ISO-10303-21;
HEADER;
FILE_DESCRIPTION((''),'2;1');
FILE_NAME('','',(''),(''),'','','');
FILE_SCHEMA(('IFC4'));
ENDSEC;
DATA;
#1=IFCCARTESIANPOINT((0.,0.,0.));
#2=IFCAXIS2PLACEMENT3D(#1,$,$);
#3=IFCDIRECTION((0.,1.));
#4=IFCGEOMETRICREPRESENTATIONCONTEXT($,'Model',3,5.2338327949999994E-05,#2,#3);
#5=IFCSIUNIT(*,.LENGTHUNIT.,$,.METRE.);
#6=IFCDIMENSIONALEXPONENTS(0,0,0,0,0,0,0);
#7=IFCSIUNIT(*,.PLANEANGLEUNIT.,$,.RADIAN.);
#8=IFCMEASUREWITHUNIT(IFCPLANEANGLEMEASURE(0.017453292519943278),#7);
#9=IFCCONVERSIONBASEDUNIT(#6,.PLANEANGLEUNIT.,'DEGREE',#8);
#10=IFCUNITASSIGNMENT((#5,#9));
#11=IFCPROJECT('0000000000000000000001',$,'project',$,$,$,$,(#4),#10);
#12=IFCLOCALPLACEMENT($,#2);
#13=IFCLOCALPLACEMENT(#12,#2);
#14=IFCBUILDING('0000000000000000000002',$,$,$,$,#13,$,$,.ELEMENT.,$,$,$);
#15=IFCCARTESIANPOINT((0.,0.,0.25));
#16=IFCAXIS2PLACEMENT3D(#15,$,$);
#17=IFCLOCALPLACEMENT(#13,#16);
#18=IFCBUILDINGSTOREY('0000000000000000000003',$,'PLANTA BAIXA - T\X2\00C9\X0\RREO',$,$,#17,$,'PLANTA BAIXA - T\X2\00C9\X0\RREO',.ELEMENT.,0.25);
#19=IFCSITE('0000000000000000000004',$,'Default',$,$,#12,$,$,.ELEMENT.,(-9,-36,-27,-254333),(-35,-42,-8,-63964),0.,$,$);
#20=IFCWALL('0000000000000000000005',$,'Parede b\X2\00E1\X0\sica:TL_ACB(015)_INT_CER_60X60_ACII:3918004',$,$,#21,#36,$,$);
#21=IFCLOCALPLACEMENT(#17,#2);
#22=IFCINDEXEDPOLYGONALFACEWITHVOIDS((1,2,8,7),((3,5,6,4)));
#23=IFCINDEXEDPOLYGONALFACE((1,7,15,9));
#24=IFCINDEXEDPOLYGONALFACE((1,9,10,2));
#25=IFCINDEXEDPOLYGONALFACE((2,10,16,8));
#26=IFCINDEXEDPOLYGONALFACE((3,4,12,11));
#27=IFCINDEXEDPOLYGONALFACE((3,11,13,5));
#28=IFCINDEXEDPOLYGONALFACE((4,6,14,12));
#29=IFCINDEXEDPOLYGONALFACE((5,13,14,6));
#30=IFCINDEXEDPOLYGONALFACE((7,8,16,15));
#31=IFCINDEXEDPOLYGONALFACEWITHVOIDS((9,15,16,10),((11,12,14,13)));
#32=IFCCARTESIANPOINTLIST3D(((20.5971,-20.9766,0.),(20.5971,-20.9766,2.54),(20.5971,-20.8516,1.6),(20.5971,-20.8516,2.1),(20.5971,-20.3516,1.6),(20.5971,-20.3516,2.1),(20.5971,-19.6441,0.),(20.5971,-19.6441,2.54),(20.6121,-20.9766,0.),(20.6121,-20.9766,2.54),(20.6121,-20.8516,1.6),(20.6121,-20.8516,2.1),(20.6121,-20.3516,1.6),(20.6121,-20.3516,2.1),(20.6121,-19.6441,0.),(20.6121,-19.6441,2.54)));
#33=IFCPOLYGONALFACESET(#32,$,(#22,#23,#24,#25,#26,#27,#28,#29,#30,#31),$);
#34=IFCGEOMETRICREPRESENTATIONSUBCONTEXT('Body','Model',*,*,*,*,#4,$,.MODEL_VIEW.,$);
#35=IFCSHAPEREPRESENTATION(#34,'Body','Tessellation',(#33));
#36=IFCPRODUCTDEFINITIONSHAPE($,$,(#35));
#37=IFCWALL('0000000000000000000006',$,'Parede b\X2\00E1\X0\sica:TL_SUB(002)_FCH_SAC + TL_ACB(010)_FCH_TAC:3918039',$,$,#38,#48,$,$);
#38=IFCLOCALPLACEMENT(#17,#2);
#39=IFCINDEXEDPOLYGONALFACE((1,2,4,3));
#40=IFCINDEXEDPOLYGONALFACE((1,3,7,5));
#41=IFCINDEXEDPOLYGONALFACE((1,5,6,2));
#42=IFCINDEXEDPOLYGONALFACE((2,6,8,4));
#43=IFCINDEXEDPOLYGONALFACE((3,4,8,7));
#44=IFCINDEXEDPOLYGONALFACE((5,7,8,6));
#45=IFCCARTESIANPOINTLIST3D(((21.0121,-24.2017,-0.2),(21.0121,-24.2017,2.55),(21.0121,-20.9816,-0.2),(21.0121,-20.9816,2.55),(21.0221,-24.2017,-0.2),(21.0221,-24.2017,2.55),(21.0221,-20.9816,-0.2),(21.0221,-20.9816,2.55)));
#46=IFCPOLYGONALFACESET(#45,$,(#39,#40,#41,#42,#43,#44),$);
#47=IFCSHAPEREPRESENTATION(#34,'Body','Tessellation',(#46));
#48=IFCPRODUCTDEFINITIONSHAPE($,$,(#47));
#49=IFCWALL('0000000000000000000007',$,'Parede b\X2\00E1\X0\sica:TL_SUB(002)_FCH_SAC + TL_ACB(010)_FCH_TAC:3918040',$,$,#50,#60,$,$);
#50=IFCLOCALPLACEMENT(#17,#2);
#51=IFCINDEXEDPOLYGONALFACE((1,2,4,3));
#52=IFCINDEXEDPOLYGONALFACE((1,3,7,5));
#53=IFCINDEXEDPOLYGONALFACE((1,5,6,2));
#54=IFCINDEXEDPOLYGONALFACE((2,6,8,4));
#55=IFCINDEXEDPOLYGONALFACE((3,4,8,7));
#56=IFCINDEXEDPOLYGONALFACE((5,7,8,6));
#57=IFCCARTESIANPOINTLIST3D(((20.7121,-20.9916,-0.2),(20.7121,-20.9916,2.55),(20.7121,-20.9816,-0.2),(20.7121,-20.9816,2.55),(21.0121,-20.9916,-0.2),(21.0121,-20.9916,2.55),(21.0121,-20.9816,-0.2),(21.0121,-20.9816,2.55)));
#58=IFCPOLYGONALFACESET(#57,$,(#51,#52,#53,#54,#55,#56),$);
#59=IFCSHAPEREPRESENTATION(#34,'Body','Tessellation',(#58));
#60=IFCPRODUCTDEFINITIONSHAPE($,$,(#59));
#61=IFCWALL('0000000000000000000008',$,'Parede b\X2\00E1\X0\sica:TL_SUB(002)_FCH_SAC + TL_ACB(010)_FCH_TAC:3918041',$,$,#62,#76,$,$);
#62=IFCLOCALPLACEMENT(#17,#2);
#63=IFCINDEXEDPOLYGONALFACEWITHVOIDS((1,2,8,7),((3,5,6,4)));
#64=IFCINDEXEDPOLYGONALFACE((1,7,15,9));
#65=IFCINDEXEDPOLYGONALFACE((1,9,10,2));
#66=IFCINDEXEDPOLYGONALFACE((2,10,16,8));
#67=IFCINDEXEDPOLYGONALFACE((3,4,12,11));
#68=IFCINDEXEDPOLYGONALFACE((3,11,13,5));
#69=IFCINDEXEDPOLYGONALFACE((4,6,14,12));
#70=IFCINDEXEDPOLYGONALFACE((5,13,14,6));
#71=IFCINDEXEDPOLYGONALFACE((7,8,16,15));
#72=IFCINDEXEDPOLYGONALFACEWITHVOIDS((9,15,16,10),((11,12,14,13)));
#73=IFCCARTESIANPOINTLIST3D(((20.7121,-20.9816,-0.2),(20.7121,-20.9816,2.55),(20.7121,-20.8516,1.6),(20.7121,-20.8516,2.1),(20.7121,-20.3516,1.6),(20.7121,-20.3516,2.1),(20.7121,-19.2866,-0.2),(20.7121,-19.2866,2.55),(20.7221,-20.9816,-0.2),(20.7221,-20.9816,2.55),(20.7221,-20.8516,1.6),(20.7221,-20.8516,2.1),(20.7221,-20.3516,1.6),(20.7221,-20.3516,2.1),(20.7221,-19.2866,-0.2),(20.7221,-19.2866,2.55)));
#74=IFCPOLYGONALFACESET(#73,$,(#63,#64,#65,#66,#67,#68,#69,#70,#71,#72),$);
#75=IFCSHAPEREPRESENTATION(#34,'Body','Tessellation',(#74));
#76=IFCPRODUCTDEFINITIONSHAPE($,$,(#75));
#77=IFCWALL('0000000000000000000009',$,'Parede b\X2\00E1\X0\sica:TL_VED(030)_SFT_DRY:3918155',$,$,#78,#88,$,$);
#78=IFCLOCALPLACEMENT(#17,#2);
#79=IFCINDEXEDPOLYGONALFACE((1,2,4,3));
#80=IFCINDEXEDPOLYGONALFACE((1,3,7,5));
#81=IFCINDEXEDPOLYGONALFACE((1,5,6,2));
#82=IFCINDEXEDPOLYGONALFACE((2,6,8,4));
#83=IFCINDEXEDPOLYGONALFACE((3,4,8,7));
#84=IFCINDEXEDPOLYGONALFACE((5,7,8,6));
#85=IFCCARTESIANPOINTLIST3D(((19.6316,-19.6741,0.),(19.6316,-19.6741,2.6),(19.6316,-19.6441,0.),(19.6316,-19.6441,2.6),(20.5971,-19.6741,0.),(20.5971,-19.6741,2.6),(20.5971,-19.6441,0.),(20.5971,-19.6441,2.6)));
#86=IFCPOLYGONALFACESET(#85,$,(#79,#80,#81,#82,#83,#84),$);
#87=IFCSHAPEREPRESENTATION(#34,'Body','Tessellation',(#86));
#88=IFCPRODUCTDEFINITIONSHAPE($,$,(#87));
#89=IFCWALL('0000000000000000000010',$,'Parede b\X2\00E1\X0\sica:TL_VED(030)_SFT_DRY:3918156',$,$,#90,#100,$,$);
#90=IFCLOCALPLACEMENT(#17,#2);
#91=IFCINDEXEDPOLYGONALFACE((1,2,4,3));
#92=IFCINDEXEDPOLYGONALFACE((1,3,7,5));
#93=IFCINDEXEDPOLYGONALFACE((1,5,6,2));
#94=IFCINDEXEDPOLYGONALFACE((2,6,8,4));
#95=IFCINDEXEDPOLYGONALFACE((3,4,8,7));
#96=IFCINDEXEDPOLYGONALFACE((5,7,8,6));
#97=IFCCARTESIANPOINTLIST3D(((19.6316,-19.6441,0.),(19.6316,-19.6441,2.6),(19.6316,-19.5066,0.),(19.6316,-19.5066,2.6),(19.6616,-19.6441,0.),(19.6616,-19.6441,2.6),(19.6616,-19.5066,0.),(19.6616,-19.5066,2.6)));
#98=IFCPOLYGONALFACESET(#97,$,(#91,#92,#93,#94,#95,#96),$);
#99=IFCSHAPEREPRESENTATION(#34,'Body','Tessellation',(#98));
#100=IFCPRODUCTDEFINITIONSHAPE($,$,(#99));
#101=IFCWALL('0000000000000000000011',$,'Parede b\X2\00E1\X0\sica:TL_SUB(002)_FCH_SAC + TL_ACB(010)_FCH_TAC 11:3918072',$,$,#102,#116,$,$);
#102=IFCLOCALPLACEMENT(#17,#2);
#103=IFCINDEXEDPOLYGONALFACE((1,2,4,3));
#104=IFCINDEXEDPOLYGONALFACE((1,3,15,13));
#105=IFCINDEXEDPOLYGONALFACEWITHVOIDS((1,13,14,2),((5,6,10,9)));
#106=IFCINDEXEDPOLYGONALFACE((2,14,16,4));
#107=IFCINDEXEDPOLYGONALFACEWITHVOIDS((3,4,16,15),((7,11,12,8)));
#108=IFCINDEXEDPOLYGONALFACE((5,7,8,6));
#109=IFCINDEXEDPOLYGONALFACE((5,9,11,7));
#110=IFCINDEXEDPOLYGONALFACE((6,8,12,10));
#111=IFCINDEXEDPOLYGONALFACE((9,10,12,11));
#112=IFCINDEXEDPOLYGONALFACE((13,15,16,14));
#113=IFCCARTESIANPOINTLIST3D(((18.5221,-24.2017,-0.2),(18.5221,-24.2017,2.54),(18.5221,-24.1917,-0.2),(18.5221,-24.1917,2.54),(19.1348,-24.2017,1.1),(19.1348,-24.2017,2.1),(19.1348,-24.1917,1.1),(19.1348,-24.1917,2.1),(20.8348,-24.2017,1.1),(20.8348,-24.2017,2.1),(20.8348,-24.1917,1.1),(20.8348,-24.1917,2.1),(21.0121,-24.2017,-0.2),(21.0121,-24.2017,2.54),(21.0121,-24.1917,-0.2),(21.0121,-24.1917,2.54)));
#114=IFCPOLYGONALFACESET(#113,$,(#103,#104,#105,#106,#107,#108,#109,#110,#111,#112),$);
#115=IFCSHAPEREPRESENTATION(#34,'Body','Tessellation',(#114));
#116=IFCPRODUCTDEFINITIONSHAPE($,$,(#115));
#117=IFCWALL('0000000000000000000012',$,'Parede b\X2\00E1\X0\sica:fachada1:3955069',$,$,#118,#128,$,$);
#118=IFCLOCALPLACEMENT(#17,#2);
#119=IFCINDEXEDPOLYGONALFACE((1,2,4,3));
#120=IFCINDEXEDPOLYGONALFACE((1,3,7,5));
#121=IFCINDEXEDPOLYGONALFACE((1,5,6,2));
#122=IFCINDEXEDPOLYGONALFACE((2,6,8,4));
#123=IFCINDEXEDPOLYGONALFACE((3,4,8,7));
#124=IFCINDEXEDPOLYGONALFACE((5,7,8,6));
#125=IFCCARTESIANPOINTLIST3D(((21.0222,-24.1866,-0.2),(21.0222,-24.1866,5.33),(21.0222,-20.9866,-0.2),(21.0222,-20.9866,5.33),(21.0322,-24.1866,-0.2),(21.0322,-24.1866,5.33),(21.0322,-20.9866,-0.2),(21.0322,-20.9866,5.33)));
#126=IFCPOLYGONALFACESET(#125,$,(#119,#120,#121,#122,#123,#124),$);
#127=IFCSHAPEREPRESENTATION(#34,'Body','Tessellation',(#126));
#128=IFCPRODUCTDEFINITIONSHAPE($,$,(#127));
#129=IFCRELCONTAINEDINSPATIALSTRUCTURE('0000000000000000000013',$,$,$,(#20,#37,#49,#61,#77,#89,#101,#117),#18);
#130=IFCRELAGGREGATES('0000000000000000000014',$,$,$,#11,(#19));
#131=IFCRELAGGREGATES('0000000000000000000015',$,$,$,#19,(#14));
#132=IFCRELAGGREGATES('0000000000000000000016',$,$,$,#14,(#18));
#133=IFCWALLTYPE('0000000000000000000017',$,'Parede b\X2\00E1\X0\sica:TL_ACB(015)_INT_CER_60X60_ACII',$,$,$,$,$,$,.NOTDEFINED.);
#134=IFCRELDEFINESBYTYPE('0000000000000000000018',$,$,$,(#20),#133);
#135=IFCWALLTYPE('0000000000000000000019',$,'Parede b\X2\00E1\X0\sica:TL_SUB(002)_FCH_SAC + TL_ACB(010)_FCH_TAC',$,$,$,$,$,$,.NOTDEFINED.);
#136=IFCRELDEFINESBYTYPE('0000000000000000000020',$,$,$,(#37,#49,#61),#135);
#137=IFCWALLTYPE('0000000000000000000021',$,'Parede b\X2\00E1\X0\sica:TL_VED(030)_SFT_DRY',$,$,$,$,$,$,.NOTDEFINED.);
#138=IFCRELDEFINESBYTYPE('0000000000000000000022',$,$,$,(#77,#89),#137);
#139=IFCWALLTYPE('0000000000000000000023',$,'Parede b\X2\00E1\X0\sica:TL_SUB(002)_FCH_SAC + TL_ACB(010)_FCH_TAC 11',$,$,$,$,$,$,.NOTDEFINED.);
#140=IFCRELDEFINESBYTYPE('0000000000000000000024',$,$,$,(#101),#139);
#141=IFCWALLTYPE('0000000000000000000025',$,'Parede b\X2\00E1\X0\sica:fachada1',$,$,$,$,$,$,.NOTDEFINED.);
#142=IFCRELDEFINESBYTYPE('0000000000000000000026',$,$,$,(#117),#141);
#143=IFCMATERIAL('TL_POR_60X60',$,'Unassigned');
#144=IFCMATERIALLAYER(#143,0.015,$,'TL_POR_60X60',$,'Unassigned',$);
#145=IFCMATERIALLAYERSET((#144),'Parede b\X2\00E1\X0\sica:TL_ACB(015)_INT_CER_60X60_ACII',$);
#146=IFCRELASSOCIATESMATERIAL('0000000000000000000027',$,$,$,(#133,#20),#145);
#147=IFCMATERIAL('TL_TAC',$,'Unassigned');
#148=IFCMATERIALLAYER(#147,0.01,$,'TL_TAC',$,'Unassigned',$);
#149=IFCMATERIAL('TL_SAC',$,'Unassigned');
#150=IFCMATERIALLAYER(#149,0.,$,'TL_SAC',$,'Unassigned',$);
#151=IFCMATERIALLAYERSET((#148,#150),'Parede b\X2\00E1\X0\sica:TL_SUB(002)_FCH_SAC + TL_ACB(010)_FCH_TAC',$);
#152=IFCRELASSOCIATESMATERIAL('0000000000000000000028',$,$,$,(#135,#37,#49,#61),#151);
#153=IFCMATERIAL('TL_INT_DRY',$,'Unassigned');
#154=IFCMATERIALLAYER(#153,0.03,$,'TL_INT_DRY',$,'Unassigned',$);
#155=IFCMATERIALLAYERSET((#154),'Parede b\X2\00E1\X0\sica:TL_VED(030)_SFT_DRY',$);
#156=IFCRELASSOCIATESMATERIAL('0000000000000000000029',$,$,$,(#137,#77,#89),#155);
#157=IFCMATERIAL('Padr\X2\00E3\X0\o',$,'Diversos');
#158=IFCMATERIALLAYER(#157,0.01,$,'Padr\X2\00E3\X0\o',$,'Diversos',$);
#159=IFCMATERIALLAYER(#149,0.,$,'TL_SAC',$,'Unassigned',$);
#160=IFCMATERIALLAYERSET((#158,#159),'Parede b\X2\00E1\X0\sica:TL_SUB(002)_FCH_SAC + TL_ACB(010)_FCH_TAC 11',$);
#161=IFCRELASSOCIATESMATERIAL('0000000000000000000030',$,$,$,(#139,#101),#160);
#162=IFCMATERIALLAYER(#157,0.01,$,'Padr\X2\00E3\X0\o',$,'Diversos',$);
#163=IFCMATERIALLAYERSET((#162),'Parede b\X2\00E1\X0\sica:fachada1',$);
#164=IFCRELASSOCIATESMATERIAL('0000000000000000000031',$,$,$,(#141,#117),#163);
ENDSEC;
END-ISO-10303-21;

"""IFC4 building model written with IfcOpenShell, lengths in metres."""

from ifc_helpers import new_model, entity, si_unit, converted_unit, direction, frame, frame_2d, origin, place, context, subcontext, project, spatial, rectangle, extrude, material, layer, layer_set, layer_usage, type_object, element, save


model = new_model("IFC4")

# Units and contexts
model_context = context("Model", 3, precision=5.2338327949999994e-05, world=origin(), true_north=direction((0.0, 1.0)))
body_context = subcontext(model_context, "Body", "Model", "MODEL_VIEW")
ifc_project = project(units=[si_unit("LENGTHUNIT", "METRE"), converted_unit("PLANEANGLEUNIT", "DEGREE", entity("IfcPlaneAngleMeasure", 0.017453292519943278), si_unit("PLANEANGLEUNIT", "RADIAN"), dimensions=[0, 0, 0, 0, 0, 0, 0])], contexts=[model_context])

# Site, building, storey
site_placement = place(None, frame((0.0, 0.0, 0.0)))
site = spatial("IfcSite", under=ifc_project, at=site_placement, Name="Default", CompositionType="ELEMENT", RefLatitude=(-9, -36, -27, -254333), RefLongitude=(-35, -42, -8, -63964), RefElevation=0.0)
building_placement = place(site_placement, origin())
building = spatial("IfcBuilding", under=site, at=building_placement, CompositionType="ELEMENT")
storey_placement = place(building_placement, frame((0.0, 0.0, 0.25)))
storey = spatial("IfcBuildingStorey", under=building, at=storey_placement, Name="PLANTA BAIXA - TÉRREO", LongName="PLANTA BAIXA - TÉRREO", CompositionType="ELEMENT", Elevation=0.25)

# Shared definitions
ifc_material_1 = material(Name="TL_SAC", Category="Unassigned")

# Shared definitions
ifc_material_2 = material(Name="TL_POR_60X60", Category="Unassigned")
ifc_layer_1 = layer(ifc_material_2, 0.015, Name="TL_POR_60X60", Category="Unassigned")
ifc_layer_set_1 = layer_set([ifc_layer_1], Name="Parede básica:TL_ACB(015)_INT_CER_60X60_ACII")
wall_type_1 = type_object("IfcWallType", Name="Parede básica:TL_ACB(015)_INT_CER_60X60_ACII", PredefinedType="NOTDEFINED", material=ifc_layer_set_1)

# Wall, opening
ifc_layer_usage_1 = layer_usage(ifc_layer_set_1, "AXIS2", "NEGATIVE", 0.0075)
wall_1_placement = place(storey_placement, frame((20.6046, -20.9766, 0.0), z_axis=(0.0, 0.0, 1.0), x_axis=(0.0, 1.0, 0.0)))
wall_1 = element("IfcWall", 1, at=wall_1_placement, inside=storey, type_object=wall_type_1, material=ifc_layer_usage_1, Name="Parede básica:TL_ACB(015)_INT_CER_60X60_ACII:3918004", context=body_context, shape_type="SweptSolid", body=[
    extrude(rectangle(XDim=1.3325, YDim=0.015, at=frame_2d((0.6662, 0.0), x_axis=(-1.0, 0.0))), origin(), (0.0, 0.0, 1.0), 2.54),
])
opening_1_placement = place(wall_1_placement, frame((20.9766, 20.6046, 1.6)))
element("IfcOpeningElement", 2, at=opening_1_placement, cuts=wall_1, PredefinedType="OPENING", context=body_context, shape_type="SweptSolid", body=[
    extrude(rectangle(XDim=0.5, YDim=0.5, at=frame_2d((0.0, 0.0), x_axis=(1.0, 0.0))), frame((-20.6016, -22.2361, 0.25), z_axis=(0.0, 1.0, 0.0), x_axis=(0.0, 0.0, 1.0)), (0.0, 0.0, 1.0), 3.048),
])

# Walls
ifc_material_3 = material(Name="TL_TAC", Category="Unassigned")
ifc_layer_2 = layer(ifc_material_3, 0.01, Name="TL_TAC", Category="Unassigned")
ifc_layer_3 = layer(ifc_material_1, 0.0, Name="TL_SAC", Category="Unassigned")
ifc_layer_set_2 = layer_set([ifc_layer_2, ifc_layer_3], Name="Parede básica:TL_SUB(002)_FCH_SAC + TL_ACB(010)_FCH_TAC")
ifc_layer_usage_2 = layer_usage(ifc_layer_set_2, "AXIS2", "NEGATIVE", 0.005)
wall_type_2 = type_object("IfcWallType", Name="Parede básica:TL_SUB(002)_FCH_SAC + TL_ACB(010)_FCH_TAC", PredefinedType="NOTDEFINED", material=ifc_layer_set_2)
wall_2_placement = place(storey_placement, frame((21.0171, -24.2017, -0.2), z_axis=(0.0, 0.0, 1.0), x_axis=(0.0, 1.0, 0.0)))
element("IfcWall", 3, at=wall_2_placement, inside=storey, type_object=wall_type_2, material=ifc_layer_usage_2, Name="Parede básica:TL_SUB(002)_FCH_SAC + TL_ACB(010)_FCH_TAC:3918039", context=body_context, shape_type="SweptSolid", body=[
    extrude(rectangle(XDim=3.2201, YDim=0.01, at=frame_2d((1.6101, 0.0), x_axis=(-1.0, 0.0))), origin(), (0.0, 0.0, 1.0), 2.75),
])
ifc_layer_usage_3 = layer_usage(ifc_layer_set_2, "AXIS2", "NEGATIVE", 0.005)
wall_3_placement = place(storey_placement, frame((21.0121, -20.9866, -0.2), z_axis=(0.0, 0.0, 1.0), x_axis=(-1.0, 0.0, 0.0)))
element("IfcWall", 4, at=wall_3_placement, inside=storey, type_object=wall_type_2, material=ifc_layer_usage_3, Name="Parede básica:TL_SUB(002)_FCH_SAC + TL_ACB(010)_FCH_TAC:3918040", context=body_context, shape_type="SweptSolid", body=[
    extrude(rectangle(XDim=0.3, YDim=0.01, at=frame_2d((0.15, 0.0), x_axis=(-1.0, 0.0))), origin(), (0.0, 0.0, 1.0), 2.75),
])

# Wall, opening
ifc_layer_usage_4 = layer_usage(ifc_layer_set_2, "AXIS2", "NEGATIVE", 0.005)
wall_4_placement = place(storey_placement, frame((20.7171, -20.9816, -0.2), z_axis=(0.0, 0.0, 1.0), x_axis=(0.0, 1.0, 0.0)))
wall_4 = element("IfcWall", 5, at=wall_4_placement, inside=storey, type_object=wall_type_2, material=ifc_layer_usage_4, Name="Parede básica:TL_SUB(002)_FCH_SAC + TL_ACB(010)_FCH_TAC:3918041", context=body_context, shape_type="SweptSolid", body=[
    extrude(rectangle(XDim=1.695, YDim=0.01, at=frame_2d((0.8475, 0.0), x_axis=(-1.0, 0.0))), origin(), (0.0, 0.0, 1.0), 2.75),
])
opening_2_placement = place(wall_4_placement, frame((20.9816, 20.7171, 1.8)))
element("IfcOpeningElement", 6, at=opening_2_placement, cuts=wall_4, PredefinedType="OPENING", context=body_context, shape_type="SweptSolid", body=[
    extrude(rectangle(XDim=0.5, YDim=0.5, at=frame_2d((0.0, 0.0), x_axis=(1.0, 0.0))), frame((-20.6016, -22.2361, 0.25), z_axis=(0.0, 1.0, 0.0), x_axis=(0.0, 0.0, 1.0)), (0.0, 0.0, 1.0), 3.048),
])

# Walls
ifc_material_4 = material(Name="TL_INT_DRY", Category="Unassigned")
ifc_layer_4 = layer(ifc_material_4, 0.03, Name="TL_INT_DRY", Category="Unassigned")
ifc_layer_set_3 = layer_set([ifc_layer_4], Name="Parede básica:TL_VED(030)_SFT_DRY")
ifc_layer_usage_5 = layer_usage(ifc_layer_set_3, "AXIS2", "NEGATIVE", 0.015)
wall_type_3 = type_object("IfcWallType", Name="Parede básica:TL_VED(030)_SFT_DRY", PredefinedType="NOTDEFINED", material=ifc_layer_set_3)
wall_5_placement = place(storey_placement, frame((20.5971, -19.6591, 0.0), z_axis=(0.0, 0.0, 1.0), x_axis=(-1.0, 0.0, 0.0)))
element("IfcWall", 7, at=wall_5_placement, inside=storey, type_object=wall_type_3, material=ifc_layer_usage_5, Name="Parede básica:TL_VED(030)_SFT_DRY:3918155", context=body_context, shape_type="SweptSolid", body=[
    extrude(rectangle(XDim=0.9655, YDim=0.03, at=frame_2d((0.4828, 0.0), x_axis=(-1.0, 0.0))), origin(), (0.0, 0.0, 1.0), 2.6),
])
ifc_layer_usage_6 = layer_usage(ifc_layer_set_3, "AXIS2", "NEGATIVE", 0.015)
wall_6_placement = place(storey_placement, frame((19.6466, -19.6441, 0.0), z_axis=(0.0, 0.0, 1.0), x_axis=(0.0, 1.0, 0.0)))
element("IfcWall", 8, at=wall_6_placement, inside=storey, type_object=wall_type_3, material=ifc_layer_usage_6, Name="Parede básica:TL_VED(030)_SFT_DRY:3918156", context=body_context, shape_type="SweptSolid", body=[
    extrude(rectangle(XDim=0.1375, YDim=0.03, at=frame_2d((0.0688, 0.0), x_axis=(-1.0, 0.0))), origin(), (0.0, 0.0, 1.0), 2.6),
])

# Wall, opening
ifc_material_5 = material(Name="Padrão", Category="Diversos")
ifc_layer_5 = layer(ifc_material_5, 0.01, Name="Padrão", Category="Diversos")
ifc_layer_6 = layer(ifc_material_1, 0.0, Name="TL_SAC", Category="Unassigned")
ifc_layer_set_4 = layer_set([ifc_layer_5, ifc_layer_6], Name="Parede básica:TL_SUB(002)_FCH_SAC + TL_ACB(010)_FCH_TAC 11")
ifc_layer_usage_7 = layer_usage(ifc_layer_set_4, "AXIS2", "NEGATIVE", 0.005)
wall_type_4 = type_object("IfcWallType", Name="Parede básica:TL_SUB(002)_FCH_SAC + TL_ACB(010)_FCH_TAC 11", PredefinedType="NOTDEFINED", material=ifc_layer_set_4)
wall_7_placement = place(storey_placement, frame((18.5221, -24.1967, -0.2)))
wall_7 = element("IfcWall", 9, at=wall_7_placement, inside=storey, type_object=wall_type_4, material=ifc_layer_usage_7, Name="Parede básica:TL_SUB(002)_FCH_SAC + TL_ACB(010)_FCH_TAC 11:3918072", context=body_context, shape_type="SweptSolid", body=[
    extrude(rectangle(XDim=2.49, YDim=0.01, at=frame_2d((1.245, 0.0), x_axis=(-1.0, 0.0))), origin(), (0.0, 0.0, 1.0), 2.74),
])
opening_3_placement = place(wall_7_placement, frame((-18.5221, 24.1967, 1.3)))
element("IfcOpeningElement", 10, at=opening_3_placement, cuts=wall_7, PredefinedType="OPENING", context=body_context, shape_type="SweptSolid", body=[
    extrude(rectangle(XDim=1.0, YDim=1.7, at=frame_2d((0.0, 0.0), x_axis=(0.0, 1.0))), frame((19.9848, -25.6157, 0.5), z_axis=(0.0, 1.0, 0.0), x_axis=(1.0, 0.0, 0.0)), (0.0, 0.0, 1.0), 3.048),
])

# Wall
ifc_layer_7 = layer(ifc_material_5, 0.01, Name="Padrão", Category="Diversos")
ifc_layer_set_5 = layer_set([ifc_layer_7], Name="Parede básica:fachada1")
ifc_layer_usage_8 = layer_usage(ifc_layer_set_5, "AXIS2", "POSITIVE", -0.005)
wall_type_5 = type_object("IfcWallType", Name="Parede básica:fachada1", PredefinedType="NOTDEFINED", material=ifc_layer_set_5)
wall_8_placement = place(storey_placement, frame((21.0272, -20.9866, -0.2), z_axis=(0.0, 0.0, 1.0), x_axis=(0.0, -1.0, 0.0)))
element("IfcWall", 11, at=wall_8_placement, inside=storey, type_object=wall_type_5, material=ifc_layer_usage_8, Name="Parede básica:fachada1:3955069", context=body_context, shape_type="SweptSolid", body=[
    extrude(rectangle(XDim=3.2, YDim=0.01, at=frame_2d((1.6, 0.0), x_axis=(-1.0, 0.0))), origin(), (0.0, 0.0, 1.0), 5.53),
])

save(model, "model.ifc")
